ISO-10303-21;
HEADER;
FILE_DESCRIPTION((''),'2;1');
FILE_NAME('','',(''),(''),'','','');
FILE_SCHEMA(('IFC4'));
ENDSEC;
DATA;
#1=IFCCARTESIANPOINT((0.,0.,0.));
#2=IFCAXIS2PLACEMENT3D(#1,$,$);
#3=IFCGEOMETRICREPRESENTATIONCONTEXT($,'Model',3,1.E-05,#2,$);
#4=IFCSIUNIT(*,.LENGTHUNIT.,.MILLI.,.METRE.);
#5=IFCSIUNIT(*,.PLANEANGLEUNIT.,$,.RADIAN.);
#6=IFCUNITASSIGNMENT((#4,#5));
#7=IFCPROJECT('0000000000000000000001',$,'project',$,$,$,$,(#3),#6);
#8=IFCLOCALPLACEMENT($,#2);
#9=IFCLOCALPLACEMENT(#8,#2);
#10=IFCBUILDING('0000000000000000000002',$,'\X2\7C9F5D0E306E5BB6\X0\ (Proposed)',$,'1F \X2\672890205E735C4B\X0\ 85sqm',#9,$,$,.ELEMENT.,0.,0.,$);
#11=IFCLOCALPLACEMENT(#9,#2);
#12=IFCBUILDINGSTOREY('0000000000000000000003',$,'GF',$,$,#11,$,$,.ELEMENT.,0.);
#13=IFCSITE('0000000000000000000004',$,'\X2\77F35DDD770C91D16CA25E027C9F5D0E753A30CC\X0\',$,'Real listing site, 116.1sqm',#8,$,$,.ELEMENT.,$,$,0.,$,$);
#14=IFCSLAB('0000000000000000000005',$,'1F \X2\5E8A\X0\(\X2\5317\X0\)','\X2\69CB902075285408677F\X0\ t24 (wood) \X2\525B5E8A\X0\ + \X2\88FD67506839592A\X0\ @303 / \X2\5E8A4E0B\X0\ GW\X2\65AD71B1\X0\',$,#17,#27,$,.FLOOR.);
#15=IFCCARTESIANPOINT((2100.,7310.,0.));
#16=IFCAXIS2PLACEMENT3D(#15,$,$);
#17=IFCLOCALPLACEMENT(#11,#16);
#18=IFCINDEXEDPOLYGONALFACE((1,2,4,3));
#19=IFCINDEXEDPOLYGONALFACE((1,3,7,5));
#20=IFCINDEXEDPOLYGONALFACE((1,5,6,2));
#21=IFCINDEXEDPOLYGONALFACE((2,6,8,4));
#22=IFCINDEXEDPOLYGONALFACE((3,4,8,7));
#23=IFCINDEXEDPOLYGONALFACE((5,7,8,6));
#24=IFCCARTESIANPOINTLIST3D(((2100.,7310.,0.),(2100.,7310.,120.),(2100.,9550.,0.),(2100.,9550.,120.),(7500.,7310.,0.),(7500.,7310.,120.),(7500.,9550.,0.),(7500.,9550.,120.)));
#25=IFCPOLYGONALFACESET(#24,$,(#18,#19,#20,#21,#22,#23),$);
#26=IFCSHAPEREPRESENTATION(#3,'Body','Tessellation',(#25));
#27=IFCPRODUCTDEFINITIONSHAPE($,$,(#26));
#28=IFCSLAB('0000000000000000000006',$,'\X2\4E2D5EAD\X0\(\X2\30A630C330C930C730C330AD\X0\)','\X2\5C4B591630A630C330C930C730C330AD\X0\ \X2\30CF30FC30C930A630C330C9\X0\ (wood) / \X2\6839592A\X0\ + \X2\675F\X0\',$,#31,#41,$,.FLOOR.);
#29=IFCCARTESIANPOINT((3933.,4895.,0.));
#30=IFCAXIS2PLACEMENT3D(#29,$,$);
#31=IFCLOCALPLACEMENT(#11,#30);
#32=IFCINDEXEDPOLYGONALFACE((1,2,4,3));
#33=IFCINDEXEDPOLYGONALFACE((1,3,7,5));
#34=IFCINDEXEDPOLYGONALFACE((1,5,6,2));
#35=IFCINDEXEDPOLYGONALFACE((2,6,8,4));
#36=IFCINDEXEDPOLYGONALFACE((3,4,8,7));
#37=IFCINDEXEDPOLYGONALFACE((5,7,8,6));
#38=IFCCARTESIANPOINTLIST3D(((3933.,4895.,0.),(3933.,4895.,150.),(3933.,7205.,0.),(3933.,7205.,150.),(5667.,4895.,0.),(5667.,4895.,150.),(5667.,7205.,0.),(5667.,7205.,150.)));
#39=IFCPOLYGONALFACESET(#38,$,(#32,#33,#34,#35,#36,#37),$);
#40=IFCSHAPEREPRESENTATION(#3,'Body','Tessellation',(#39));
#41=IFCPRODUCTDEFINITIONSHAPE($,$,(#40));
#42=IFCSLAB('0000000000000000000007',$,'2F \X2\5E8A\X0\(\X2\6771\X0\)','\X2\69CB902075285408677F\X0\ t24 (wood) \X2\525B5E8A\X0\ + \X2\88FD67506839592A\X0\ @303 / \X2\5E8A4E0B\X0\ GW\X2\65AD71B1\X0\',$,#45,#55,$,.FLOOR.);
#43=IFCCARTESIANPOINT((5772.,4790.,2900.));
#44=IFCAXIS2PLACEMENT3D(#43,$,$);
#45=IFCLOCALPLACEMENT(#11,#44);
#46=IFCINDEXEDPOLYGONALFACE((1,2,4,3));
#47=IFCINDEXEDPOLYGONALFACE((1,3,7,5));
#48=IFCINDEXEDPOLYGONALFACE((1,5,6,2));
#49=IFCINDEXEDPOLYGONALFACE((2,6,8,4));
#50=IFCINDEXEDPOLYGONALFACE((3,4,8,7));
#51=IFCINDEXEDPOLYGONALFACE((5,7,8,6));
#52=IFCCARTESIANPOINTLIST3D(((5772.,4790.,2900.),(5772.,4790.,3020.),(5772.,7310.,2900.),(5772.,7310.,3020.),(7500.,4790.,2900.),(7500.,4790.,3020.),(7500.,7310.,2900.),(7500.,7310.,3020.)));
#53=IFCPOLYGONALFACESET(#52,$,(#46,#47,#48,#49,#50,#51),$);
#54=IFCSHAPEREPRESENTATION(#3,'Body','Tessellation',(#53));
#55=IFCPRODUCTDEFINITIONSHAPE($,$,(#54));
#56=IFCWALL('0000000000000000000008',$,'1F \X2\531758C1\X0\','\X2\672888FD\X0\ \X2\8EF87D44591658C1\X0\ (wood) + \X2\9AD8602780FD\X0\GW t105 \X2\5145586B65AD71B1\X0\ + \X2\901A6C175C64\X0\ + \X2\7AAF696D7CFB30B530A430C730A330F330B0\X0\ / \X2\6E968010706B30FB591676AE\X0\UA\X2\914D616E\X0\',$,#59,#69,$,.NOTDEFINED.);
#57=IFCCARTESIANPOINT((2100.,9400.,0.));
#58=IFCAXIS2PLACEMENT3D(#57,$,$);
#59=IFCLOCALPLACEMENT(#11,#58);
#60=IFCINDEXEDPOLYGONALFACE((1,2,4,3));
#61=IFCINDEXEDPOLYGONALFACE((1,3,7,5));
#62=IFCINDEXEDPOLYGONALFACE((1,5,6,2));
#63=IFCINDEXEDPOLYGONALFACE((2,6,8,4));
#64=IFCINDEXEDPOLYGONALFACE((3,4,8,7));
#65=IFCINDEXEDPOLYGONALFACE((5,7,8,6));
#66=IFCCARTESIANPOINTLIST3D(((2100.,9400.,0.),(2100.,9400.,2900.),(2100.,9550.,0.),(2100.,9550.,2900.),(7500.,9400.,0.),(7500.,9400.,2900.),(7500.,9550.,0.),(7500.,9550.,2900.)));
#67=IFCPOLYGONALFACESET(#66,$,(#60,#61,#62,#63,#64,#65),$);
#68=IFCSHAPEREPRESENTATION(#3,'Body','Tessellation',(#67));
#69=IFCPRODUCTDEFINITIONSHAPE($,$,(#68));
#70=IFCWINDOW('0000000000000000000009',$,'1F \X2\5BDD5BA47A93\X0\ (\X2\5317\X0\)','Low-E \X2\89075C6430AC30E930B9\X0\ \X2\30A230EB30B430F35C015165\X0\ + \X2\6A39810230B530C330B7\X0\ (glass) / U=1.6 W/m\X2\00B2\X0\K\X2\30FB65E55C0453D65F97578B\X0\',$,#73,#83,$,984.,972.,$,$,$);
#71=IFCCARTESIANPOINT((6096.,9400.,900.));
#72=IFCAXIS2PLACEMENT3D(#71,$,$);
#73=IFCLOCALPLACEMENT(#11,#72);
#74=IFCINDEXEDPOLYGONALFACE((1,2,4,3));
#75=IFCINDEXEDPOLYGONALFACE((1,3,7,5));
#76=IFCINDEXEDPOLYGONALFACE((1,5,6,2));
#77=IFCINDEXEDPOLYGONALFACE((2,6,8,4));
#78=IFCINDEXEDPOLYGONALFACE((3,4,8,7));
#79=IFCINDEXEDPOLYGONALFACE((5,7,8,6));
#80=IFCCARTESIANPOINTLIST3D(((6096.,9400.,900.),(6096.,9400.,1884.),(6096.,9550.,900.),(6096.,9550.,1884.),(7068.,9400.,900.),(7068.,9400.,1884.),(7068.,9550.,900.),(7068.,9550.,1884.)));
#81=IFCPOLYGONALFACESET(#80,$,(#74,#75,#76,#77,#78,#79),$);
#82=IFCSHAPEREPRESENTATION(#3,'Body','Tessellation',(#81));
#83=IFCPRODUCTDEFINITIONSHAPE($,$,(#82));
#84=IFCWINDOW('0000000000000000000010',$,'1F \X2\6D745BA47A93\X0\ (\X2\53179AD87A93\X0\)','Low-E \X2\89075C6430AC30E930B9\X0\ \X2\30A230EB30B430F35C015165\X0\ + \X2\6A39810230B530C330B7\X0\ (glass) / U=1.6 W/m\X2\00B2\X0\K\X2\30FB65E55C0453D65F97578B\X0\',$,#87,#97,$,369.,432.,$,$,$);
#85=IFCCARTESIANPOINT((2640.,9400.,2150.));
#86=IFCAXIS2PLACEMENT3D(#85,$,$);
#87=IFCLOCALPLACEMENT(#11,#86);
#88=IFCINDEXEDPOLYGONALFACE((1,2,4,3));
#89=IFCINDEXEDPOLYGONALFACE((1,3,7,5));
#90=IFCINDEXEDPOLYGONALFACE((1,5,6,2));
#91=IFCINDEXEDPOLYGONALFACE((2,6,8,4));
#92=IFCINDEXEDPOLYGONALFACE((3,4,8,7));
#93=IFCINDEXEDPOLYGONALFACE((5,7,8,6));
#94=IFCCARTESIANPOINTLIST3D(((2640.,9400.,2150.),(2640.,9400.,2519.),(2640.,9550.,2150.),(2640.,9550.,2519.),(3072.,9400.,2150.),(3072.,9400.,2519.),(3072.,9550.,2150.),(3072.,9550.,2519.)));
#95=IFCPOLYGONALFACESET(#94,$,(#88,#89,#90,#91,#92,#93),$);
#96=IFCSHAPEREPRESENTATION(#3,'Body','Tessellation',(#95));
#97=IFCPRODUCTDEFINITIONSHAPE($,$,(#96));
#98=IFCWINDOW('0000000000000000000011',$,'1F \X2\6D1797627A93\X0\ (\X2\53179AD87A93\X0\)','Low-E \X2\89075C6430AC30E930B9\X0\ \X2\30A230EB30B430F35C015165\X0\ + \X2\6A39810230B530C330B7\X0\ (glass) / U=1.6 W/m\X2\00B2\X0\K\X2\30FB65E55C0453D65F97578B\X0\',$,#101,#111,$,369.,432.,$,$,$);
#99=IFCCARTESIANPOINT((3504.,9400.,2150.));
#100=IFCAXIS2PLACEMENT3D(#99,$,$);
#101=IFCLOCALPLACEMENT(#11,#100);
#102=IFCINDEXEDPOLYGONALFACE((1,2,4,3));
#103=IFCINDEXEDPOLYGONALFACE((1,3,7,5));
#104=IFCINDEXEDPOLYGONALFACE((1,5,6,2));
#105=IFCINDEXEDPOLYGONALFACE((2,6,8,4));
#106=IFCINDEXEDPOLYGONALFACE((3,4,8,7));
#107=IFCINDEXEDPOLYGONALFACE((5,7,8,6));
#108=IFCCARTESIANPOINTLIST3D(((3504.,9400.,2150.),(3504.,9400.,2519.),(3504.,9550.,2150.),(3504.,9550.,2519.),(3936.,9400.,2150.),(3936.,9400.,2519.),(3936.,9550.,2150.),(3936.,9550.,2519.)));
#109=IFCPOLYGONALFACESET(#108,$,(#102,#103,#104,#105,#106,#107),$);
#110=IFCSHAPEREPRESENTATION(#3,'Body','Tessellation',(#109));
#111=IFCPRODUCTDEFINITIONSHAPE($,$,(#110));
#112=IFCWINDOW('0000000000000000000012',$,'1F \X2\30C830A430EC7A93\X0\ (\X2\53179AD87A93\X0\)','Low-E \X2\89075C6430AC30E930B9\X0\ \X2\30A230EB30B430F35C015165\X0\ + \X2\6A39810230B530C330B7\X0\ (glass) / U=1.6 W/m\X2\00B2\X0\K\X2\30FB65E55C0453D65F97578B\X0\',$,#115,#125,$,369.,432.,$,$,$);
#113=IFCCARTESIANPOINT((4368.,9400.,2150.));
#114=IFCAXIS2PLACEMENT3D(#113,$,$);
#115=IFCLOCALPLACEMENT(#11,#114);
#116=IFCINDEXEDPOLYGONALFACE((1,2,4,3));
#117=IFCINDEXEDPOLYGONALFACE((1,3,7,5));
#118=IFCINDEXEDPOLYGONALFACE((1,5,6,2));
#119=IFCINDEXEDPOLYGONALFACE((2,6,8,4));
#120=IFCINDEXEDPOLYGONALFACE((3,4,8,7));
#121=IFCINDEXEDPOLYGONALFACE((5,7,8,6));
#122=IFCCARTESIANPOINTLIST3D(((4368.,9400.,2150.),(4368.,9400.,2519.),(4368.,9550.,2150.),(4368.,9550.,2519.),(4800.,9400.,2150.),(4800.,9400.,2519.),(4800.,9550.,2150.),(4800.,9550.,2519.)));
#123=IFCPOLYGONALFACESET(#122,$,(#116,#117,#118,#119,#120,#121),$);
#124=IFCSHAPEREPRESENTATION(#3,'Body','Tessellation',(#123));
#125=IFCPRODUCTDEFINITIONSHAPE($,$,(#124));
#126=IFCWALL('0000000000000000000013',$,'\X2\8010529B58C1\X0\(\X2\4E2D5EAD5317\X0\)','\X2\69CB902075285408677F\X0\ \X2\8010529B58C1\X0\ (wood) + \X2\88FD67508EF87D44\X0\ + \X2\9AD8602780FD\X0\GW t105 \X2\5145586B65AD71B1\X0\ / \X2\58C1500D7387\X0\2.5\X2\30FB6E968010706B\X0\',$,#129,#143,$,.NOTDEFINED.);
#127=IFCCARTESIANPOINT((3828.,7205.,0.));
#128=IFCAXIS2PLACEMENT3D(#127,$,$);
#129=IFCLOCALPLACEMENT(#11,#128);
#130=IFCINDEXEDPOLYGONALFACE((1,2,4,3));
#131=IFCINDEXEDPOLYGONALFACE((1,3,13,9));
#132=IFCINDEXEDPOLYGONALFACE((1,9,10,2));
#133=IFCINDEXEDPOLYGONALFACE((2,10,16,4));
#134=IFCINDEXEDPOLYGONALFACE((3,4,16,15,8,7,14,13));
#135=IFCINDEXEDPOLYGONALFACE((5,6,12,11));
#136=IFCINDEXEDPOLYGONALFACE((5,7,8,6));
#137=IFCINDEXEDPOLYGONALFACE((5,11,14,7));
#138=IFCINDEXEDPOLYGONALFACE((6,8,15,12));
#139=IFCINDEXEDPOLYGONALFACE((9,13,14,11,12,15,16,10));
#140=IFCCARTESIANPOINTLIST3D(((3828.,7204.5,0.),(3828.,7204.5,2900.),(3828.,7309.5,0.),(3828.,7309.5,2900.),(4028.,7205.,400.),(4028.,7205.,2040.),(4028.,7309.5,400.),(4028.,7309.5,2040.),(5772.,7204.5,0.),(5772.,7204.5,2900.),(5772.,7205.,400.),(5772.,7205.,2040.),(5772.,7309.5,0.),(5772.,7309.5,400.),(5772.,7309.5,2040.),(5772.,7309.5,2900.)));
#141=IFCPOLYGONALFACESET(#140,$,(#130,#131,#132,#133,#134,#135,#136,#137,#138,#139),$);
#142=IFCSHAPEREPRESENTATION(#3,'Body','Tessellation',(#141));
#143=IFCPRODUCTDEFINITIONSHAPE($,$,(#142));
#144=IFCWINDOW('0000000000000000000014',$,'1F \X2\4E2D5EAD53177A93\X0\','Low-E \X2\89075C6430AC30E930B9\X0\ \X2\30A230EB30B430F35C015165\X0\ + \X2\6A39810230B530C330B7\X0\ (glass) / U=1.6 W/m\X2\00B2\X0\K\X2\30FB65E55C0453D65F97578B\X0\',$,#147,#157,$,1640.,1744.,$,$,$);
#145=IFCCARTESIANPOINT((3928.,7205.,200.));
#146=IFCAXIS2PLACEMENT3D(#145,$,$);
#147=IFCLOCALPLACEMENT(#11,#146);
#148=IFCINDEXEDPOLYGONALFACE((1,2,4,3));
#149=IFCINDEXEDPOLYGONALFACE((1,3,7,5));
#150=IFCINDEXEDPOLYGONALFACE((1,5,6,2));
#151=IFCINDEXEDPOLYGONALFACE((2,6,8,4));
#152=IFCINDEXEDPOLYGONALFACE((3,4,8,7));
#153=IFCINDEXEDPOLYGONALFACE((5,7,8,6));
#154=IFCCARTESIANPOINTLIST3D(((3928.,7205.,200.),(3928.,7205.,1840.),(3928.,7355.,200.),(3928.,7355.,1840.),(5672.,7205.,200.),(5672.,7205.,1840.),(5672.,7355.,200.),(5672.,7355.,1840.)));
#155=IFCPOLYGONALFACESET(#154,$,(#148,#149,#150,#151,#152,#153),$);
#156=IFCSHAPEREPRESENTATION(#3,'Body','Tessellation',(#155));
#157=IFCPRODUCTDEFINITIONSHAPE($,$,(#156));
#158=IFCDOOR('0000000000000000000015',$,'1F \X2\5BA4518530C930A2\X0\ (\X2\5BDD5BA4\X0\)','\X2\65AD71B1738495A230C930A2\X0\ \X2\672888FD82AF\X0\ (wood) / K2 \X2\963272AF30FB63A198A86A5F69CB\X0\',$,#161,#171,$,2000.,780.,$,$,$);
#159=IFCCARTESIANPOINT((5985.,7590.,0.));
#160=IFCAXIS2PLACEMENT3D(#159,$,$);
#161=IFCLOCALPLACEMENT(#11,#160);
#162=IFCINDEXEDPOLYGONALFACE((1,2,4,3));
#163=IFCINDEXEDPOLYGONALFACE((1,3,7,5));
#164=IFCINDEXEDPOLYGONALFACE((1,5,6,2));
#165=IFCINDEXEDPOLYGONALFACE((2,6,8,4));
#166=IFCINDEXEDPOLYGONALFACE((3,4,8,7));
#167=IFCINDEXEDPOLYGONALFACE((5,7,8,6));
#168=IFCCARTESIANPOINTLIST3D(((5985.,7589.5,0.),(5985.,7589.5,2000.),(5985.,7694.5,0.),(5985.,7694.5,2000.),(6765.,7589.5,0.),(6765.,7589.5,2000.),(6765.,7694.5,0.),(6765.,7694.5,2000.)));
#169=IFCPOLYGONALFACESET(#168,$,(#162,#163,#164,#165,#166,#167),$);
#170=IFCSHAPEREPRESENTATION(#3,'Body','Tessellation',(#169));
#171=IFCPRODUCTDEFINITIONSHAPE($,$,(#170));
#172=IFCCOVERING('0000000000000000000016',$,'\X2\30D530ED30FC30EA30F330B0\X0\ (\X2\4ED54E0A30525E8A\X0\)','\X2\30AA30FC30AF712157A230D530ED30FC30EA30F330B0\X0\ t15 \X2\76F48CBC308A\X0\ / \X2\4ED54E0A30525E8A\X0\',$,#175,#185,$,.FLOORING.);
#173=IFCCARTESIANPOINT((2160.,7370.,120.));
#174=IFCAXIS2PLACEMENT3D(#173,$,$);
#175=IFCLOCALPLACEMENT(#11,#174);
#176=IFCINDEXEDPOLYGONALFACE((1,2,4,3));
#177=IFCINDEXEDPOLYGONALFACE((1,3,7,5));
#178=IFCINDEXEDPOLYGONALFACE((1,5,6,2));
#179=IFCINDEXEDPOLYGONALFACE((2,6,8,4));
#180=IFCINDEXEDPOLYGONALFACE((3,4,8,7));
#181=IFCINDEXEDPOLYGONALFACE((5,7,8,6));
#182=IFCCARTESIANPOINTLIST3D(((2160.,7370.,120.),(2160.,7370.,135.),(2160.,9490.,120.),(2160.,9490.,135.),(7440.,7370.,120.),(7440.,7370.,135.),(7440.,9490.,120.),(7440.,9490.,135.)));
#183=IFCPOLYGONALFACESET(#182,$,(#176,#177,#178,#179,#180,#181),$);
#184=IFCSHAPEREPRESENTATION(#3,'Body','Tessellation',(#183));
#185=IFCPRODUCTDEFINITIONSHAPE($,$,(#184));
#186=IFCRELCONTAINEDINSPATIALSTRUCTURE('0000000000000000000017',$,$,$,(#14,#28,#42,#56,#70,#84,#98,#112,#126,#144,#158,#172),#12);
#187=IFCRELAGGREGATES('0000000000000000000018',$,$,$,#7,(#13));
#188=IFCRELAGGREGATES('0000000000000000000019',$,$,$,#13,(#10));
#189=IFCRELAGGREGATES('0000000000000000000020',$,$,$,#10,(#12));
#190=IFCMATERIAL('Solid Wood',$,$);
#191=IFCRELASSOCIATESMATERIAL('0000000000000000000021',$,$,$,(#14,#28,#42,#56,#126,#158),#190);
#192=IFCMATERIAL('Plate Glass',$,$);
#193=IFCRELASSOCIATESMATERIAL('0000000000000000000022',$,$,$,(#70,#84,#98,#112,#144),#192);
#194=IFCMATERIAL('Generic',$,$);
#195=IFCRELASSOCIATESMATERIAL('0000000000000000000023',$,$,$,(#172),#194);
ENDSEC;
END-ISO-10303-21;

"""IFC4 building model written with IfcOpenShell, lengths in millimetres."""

from ifc_helpers import new_model, si_unit, frame, frame_2d, origin, place, context, project, spatial, rectangle, extrude, material, element, fill, save


model = new_model("IFC4")

# Units and contexts
model_context = context("Model", 3, precision=1e-05, world=origin())
ifc_project = project(units=[si_unit("LENGTHUNIT", "METRE", prefix="MILLI"), si_unit("PLANEANGLEUNIT", "RADIAN")], contexts=[model_context])

# Site, building, storey
site_placement = place(None, origin())
site = spatial("IfcSite", under=ifc_project, at=site_placement, Name="石川県金沢市粟崎町ヌ", ObjectType="Real listing site, 116.1sqm", CompositionType="ELEMENT", RefElevation=0.0)
building_placement = place(site_placement, origin())
building = spatial("IfcBuilding", under=site, at=building_placement, Name="粟崎の家 (Proposed)", ObjectType="1F 木造平屋 85sqm", CompositionType="ELEMENT", ElevationOfRefHeight=0.0, ElevationOfTerrain=0.0)
storey_placement = place(building_placement, origin())
storey = spatial("IfcBuildingStorey", under=building, at=storey_placement, Name="GF", CompositionType="ELEMENT", Elevation=0.0)

# Slabs
ifc_material_1 = material(Name="Solid Wood")
slab_1_placement = place(storey_placement, frame((2100.0, 7310.0, 0.0)))
element("IfcSlab", 1, at=slab_1_placement, inside=storey, material=ifc_material_1, Name="1F 床(北)", Description="構造用合板 t24 (wood) 剛床 + 製材根太 @303 / 床下 GW断熱", PredefinedType="FLOOR", context=model_context, shape_type="SweptSolid", body=[
    extrude(rectangle(XDim=5400.0, YDim=2240.0, at=frame_2d((2700.0, 1120.0))), frame((2100.0, 7310.0, 0.0)), (0.0, 0.0, 1.0), 120.0),
])
slab_2_placement = place(storey_placement, frame((3933.0, 4895.0, 0.0)))
element("IfcSlab", 2, at=slab_2_placement, inside=storey, material=ifc_material_1, Name="中庭(ウッドデッキ)", Description="屋外ウッドデッキ ハードウッド (wood) / 根太 + 束", PredefinedType="FLOOR", context=model_context, shape_type="SweptSolid", body=[
    extrude(rectangle(XDim=1734.0, YDim=2310.0, at=frame_2d((867.0, 1155.0))), frame((3933.0, 4895.0, 0.0)), (0.0, 0.0, 1.0), 150.0),
])
slab_3_placement = place(storey_placement, frame((5772.0, 4790.0, 2900.0)))
element("IfcSlab", 3, at=slab_3_placement, inside=storey, material=ifc_material_1, Name="2F 床(東)", Description="構造用合板 t24 (wood) 剛床 + 製材根太 @303 / 床下 GW断熱", PredefinedType="FLOOR", context=model_context, shape_type="SweptSolid", body=[
    extrude(rectangle(XDim=1728.0, YDim=2520.0, at=frame_2d((864.0, 1260.0))), frame((5772.0, 4790.0, 2900.0)), (0.0, 0.0, 1.0), 120.0),
])

# Wall, openings, windows
wall_1_placement = place(storey_placement, frame((2100.0, 9400.0, 0.0)))
wall_1 = element("IfcWall", 4, at=wall_1_placement, inside=storey, material=ifc_material_1, Name="1F 北壁", Description="木製 軸組外壁 (wood) + 高性能GW t105 充填断熱 + 通気層 + 窯業系サイディング / 準耐火・外皮UA配慮", PredefinedType="NOTDEFINED", context=model_context, shape_type="SweptSolid", body=[
    extrude(rectangle(XDim=5400.0, YDim=150.0, at=frame_2d((2700.0, 75.0))), frame((2100.0, 9400.0, 0.0)), (0.0, 0.0, 1.0), 2900.0),
])
opening_1_placement = place(storey_placement, frame((6096.0, 9400.0, 900.0)))
opening_1 = element("IfcOpeningElement", 5, at=opening_1_placement, cuts=wall_1, PredefinedType="NOTDEFINED", context=model_context, shape_type="SweptSolid", body=[
    extrude(rectangle(XDim=972.0, YDim=150.0, at=frame_2d((486.0, 75.0))), frame((6096.0, 9400.0, 900.0)), (0.0, 0.0, 1.0), 984.0),
])
opening_2_placement = place(storey_placement, frame((2640.0, 9400.0, 2150.0)))
opening_2 = element("IfcOpeningElement", 6, at=opening_2_placement, cuts=wall_1, PredefinedType="NOTDEFINED", context=model_context, shape_type="SweptSolid", body=[
    extrude(rectangle(XDim=432.0, YDim=150.0, at=frame_2d((216.0, 75.0))), frame((2640.0, 9400.0, 2150.0)), (0.0, 0.0, 1.0), 369.0),
])
opening_3_placement = place(storey_placement, frame((3504.0, 9400.0, 2150.0)))
opening_3 = element("IfcOpeningElement", 7, at=opening_3_placement, cuts=wall_1, PredefinedType="NOTDEFINED", context=model_context, shape_type="SweptSolid", body=[
    extrude(rectangle(XDim=432.0, YDim=150.0, at=frame_2d((216.0, 75.0))), frame((3504.0, 9400.0, 2150.0)), (0.0, 0.0, 1.0), 369.0),
])
opening_4_placement = place(storey_placement, frame((4368.0, 9400.0, 2150.0)))
opening_4 = element("IfcOpeningElement", 8, at=opening_4_placement, cuts=wall_1, PredefinedType="NOTDEFINED", context=model_context, shape_type="SweptSolid", body=[
    extrude(rectangle(XDim=432.0, YDim=150.0, at=frame_2d((216.0, 75.0))), frame((4368.0, 9400.0, 2150.0)), (0.0, 0.0, 1.0), 369.0),
])
ifc_material_2 = material(Name="Plate Glass")
window_1_placement = place(storey_placement, frame((6096.0, 9400.0, 900.0)))
window_1 = element("IfcWindow", 9, at=window_1_placement, inside=storey, material=ifc_material_2, Name="1F 寝室窓 (北)", Description="Low-E 複層ガラス アルゴン封入 + 樹脂サッシ (glass) / U=1.6 W/m²K・日射取得型", OverallHeight=984.0, OverallWidth=972.0, context=model_context, shape_type="SweptSolid", body=[
    extrude(rectangle(XDim=972.0, YDim=150.0, at=frame_2d((486.0, 75.0))), frame((6096.0, 9400.0, 900.0)), (0.0, 0.0, 1.0), 984.0),
])
fill(opening_1, window_1)
window_2_placement = place(storey_placement, frame((2640.0, 9400.0, 2150.0)))
window_2 = element("IfcWindow", 10, at=window_2_placement, inside=storey, material=ifc_material_2, Name="1F 浴室窓 (北高窓)", Description="Low-E 複層ガラス アルゴン封入 + 樹脂サッシ (glass) / U=1.6 W/m²K・日射取得型", OverallHeight=369.0, OverallWidth=432.0, context=model_context, shape_type="SweptSolid", body=[
    extrude(rectangle(XDim=432.0, YDim=150.0, at=frame_2d((216.0, 75.0))), frame((2640.0, 9400.0, 2150.0)), (0.0, 0.0, 1.0), 369.0),
])
fill(opening_2, window_2)
window_3_placement = place(storey_placement, frame((3504.0, 9400.0, 2150.0)))
window_3 = element("IfcWindow", 11, at=window_3_placement, inside=storey, material=ifc_material_2, Name="1F 洗面窓 (北高窓)", Description="Low-E 複層ガラス アルゴン封入 + 樹脂サッシ (glass) / U=1.6 W/m²K・日射取得型", OverallHeight=369.0, OverallWidth=432.0, context=model_context, shape_type="SweptSolid", body=[
    extrude(rectangle(XDim=432.0, YDim=150.0, at=frame_2d((216.0, 75.0))), frame((3504.0, 9400.0, 2150.0)), (0.0, 0.0, 1.0), 369.0),
])
fill(opening_3, window_3)
window_4_placement = place(storey_placement, frame((4368.0, 9400.0, 2150.0)))
window_4 = element("IfcWindow", 12, at=window_4_placement, inside=storey, material=ifc_material_2, Name="1F トイレ窓 (北高窓)", Description="Low-E 複層ガラス アルゴン封入 + 樹脂サッシ (glass) / U=1.6 W/m²K・日射取得型", OverallHeight=369.0, OverallWidth=432.0, context=model_context, shape_type="SweptSolid", body=[
    extrude(rectangle(XDim=432.0, YDim=150.0, at=frame_2d((216.0, 75.0))), frame((4368.0, 9400.0, 2150.0)), (0.0, 0.0, 1.0), 369.0),
])
fill(opening_4, window_4)

# Wall, opening, window
wall_2_placement = place(storey_placement, frame((3828.0, 7205.0, 0.0)))
wall_2 = element("IfcWall", 13, at=wall_2_placement, inside=storey, material=ifc_material_1, Name="耐力壁(中庭北)", Description="構造用合板 耐力壁 (wood) + 製材軸組 + 高性能GW t105 充填断熱 / 壁倍率2.5・準耐火", PredefinedType="NOTDEFINED", context=model_context, shape_type="SweptSolid", body=[
    extrude(rectangle(XDim=1944.0, YDim=105.0, at=frame_2d((972.0, 52.0))), frame((3828.0, 7205.0, 0.0)), (0.0, 0.0, 1.0), 2900.0),
])
opening_5_placement = place(storey_placement, frame((3928.0, 7205.0, 200.0)))
opening_5 = element("IfcOpeningElement", 14, at=opening_5_placement, cuts=wall_2, PredefinedType="NOTDEFINED", context=model_context, shape_type="SweptSolid", body=[
    extrude(rectangle(XDim=1744.0, YDim=150.0, at=frame_2d((872.0, 75.0))), frame((3928.0, 7205.0, 200.0)), (0.0, 0.0, 1.0), 1640.0),
])
window_5_placement = place(storey_placement, frame((3928.0, 7205.0, 200.0)))
window_5 = element("IfcWindow", 15, at=window_5_placement, inside=storey, material=ifc_material_2, Name="1F 中庭北窓", Description="Low-E 複層ガラス アルゴン封入 + 樹脂サッシ (glass) / U=1.6 W/m²K・日射取得型", OverallHeight=1640.0, OverallWidth=1744.0, context=model_context, shape_type="SweptSolid", body=[
    extrude(rectangle(XDim=1744.0, YDim=150.0, at=frame_2d((872.0, 75.0))), frame((3928.0, 7205.0, 200.0)), (0.0, 0.0, 1.0), 1640.0),
])
fill(opening_5, window_5)

# Door
door_1_placement = place(storey_placement, frame((5985.0, 7590.0, 0.0)))
element("IfcDoor", 16, at=door_1_placement, inside=storey, material=ifc_material_1, Name="1F 室内ドア (寝室)", Description="断熱玄関ドア 木製芯 (wood) / K2 防犯・採風機構", OverallHeight=2000.0, OverallWidth=780.0, context=model_context, shape_type="SweptSolid", body=[
    extrude(rectangle(XDim=780.0, YDim=105.0, at=frame_2d((390.0, 52.0))), frame((5985.0, 7590.0, 0.0)), (0.0, 0.0, 1.0), 2000.0),
])

# Covering
ifc_material_3 = material(Name="Generic")
covering_1_placement = place(storey_placement, frame((2160.0, 7370.0, 120.0)))
element("IfcCovering", 17, at=covering_1_placement, inside=storey, material=ifc_material_3, Name="フローリング (仕上げ床)", Description="オーク無垢フローリング t15 直貼り / 仕上げ床", PredefinedType="FLOORING", context=model_context, shape_type="SweptSolid", body=[
    extrude(rectangle(XDim=5280.0, YDim=2120.0, at=frame_2d((2640.0, 1060.0))), frame((2160.0, 7370.0, 120.0)), (0.0, 0.0, 1.0), 15.0),
])

save(model, "model.ifc")
